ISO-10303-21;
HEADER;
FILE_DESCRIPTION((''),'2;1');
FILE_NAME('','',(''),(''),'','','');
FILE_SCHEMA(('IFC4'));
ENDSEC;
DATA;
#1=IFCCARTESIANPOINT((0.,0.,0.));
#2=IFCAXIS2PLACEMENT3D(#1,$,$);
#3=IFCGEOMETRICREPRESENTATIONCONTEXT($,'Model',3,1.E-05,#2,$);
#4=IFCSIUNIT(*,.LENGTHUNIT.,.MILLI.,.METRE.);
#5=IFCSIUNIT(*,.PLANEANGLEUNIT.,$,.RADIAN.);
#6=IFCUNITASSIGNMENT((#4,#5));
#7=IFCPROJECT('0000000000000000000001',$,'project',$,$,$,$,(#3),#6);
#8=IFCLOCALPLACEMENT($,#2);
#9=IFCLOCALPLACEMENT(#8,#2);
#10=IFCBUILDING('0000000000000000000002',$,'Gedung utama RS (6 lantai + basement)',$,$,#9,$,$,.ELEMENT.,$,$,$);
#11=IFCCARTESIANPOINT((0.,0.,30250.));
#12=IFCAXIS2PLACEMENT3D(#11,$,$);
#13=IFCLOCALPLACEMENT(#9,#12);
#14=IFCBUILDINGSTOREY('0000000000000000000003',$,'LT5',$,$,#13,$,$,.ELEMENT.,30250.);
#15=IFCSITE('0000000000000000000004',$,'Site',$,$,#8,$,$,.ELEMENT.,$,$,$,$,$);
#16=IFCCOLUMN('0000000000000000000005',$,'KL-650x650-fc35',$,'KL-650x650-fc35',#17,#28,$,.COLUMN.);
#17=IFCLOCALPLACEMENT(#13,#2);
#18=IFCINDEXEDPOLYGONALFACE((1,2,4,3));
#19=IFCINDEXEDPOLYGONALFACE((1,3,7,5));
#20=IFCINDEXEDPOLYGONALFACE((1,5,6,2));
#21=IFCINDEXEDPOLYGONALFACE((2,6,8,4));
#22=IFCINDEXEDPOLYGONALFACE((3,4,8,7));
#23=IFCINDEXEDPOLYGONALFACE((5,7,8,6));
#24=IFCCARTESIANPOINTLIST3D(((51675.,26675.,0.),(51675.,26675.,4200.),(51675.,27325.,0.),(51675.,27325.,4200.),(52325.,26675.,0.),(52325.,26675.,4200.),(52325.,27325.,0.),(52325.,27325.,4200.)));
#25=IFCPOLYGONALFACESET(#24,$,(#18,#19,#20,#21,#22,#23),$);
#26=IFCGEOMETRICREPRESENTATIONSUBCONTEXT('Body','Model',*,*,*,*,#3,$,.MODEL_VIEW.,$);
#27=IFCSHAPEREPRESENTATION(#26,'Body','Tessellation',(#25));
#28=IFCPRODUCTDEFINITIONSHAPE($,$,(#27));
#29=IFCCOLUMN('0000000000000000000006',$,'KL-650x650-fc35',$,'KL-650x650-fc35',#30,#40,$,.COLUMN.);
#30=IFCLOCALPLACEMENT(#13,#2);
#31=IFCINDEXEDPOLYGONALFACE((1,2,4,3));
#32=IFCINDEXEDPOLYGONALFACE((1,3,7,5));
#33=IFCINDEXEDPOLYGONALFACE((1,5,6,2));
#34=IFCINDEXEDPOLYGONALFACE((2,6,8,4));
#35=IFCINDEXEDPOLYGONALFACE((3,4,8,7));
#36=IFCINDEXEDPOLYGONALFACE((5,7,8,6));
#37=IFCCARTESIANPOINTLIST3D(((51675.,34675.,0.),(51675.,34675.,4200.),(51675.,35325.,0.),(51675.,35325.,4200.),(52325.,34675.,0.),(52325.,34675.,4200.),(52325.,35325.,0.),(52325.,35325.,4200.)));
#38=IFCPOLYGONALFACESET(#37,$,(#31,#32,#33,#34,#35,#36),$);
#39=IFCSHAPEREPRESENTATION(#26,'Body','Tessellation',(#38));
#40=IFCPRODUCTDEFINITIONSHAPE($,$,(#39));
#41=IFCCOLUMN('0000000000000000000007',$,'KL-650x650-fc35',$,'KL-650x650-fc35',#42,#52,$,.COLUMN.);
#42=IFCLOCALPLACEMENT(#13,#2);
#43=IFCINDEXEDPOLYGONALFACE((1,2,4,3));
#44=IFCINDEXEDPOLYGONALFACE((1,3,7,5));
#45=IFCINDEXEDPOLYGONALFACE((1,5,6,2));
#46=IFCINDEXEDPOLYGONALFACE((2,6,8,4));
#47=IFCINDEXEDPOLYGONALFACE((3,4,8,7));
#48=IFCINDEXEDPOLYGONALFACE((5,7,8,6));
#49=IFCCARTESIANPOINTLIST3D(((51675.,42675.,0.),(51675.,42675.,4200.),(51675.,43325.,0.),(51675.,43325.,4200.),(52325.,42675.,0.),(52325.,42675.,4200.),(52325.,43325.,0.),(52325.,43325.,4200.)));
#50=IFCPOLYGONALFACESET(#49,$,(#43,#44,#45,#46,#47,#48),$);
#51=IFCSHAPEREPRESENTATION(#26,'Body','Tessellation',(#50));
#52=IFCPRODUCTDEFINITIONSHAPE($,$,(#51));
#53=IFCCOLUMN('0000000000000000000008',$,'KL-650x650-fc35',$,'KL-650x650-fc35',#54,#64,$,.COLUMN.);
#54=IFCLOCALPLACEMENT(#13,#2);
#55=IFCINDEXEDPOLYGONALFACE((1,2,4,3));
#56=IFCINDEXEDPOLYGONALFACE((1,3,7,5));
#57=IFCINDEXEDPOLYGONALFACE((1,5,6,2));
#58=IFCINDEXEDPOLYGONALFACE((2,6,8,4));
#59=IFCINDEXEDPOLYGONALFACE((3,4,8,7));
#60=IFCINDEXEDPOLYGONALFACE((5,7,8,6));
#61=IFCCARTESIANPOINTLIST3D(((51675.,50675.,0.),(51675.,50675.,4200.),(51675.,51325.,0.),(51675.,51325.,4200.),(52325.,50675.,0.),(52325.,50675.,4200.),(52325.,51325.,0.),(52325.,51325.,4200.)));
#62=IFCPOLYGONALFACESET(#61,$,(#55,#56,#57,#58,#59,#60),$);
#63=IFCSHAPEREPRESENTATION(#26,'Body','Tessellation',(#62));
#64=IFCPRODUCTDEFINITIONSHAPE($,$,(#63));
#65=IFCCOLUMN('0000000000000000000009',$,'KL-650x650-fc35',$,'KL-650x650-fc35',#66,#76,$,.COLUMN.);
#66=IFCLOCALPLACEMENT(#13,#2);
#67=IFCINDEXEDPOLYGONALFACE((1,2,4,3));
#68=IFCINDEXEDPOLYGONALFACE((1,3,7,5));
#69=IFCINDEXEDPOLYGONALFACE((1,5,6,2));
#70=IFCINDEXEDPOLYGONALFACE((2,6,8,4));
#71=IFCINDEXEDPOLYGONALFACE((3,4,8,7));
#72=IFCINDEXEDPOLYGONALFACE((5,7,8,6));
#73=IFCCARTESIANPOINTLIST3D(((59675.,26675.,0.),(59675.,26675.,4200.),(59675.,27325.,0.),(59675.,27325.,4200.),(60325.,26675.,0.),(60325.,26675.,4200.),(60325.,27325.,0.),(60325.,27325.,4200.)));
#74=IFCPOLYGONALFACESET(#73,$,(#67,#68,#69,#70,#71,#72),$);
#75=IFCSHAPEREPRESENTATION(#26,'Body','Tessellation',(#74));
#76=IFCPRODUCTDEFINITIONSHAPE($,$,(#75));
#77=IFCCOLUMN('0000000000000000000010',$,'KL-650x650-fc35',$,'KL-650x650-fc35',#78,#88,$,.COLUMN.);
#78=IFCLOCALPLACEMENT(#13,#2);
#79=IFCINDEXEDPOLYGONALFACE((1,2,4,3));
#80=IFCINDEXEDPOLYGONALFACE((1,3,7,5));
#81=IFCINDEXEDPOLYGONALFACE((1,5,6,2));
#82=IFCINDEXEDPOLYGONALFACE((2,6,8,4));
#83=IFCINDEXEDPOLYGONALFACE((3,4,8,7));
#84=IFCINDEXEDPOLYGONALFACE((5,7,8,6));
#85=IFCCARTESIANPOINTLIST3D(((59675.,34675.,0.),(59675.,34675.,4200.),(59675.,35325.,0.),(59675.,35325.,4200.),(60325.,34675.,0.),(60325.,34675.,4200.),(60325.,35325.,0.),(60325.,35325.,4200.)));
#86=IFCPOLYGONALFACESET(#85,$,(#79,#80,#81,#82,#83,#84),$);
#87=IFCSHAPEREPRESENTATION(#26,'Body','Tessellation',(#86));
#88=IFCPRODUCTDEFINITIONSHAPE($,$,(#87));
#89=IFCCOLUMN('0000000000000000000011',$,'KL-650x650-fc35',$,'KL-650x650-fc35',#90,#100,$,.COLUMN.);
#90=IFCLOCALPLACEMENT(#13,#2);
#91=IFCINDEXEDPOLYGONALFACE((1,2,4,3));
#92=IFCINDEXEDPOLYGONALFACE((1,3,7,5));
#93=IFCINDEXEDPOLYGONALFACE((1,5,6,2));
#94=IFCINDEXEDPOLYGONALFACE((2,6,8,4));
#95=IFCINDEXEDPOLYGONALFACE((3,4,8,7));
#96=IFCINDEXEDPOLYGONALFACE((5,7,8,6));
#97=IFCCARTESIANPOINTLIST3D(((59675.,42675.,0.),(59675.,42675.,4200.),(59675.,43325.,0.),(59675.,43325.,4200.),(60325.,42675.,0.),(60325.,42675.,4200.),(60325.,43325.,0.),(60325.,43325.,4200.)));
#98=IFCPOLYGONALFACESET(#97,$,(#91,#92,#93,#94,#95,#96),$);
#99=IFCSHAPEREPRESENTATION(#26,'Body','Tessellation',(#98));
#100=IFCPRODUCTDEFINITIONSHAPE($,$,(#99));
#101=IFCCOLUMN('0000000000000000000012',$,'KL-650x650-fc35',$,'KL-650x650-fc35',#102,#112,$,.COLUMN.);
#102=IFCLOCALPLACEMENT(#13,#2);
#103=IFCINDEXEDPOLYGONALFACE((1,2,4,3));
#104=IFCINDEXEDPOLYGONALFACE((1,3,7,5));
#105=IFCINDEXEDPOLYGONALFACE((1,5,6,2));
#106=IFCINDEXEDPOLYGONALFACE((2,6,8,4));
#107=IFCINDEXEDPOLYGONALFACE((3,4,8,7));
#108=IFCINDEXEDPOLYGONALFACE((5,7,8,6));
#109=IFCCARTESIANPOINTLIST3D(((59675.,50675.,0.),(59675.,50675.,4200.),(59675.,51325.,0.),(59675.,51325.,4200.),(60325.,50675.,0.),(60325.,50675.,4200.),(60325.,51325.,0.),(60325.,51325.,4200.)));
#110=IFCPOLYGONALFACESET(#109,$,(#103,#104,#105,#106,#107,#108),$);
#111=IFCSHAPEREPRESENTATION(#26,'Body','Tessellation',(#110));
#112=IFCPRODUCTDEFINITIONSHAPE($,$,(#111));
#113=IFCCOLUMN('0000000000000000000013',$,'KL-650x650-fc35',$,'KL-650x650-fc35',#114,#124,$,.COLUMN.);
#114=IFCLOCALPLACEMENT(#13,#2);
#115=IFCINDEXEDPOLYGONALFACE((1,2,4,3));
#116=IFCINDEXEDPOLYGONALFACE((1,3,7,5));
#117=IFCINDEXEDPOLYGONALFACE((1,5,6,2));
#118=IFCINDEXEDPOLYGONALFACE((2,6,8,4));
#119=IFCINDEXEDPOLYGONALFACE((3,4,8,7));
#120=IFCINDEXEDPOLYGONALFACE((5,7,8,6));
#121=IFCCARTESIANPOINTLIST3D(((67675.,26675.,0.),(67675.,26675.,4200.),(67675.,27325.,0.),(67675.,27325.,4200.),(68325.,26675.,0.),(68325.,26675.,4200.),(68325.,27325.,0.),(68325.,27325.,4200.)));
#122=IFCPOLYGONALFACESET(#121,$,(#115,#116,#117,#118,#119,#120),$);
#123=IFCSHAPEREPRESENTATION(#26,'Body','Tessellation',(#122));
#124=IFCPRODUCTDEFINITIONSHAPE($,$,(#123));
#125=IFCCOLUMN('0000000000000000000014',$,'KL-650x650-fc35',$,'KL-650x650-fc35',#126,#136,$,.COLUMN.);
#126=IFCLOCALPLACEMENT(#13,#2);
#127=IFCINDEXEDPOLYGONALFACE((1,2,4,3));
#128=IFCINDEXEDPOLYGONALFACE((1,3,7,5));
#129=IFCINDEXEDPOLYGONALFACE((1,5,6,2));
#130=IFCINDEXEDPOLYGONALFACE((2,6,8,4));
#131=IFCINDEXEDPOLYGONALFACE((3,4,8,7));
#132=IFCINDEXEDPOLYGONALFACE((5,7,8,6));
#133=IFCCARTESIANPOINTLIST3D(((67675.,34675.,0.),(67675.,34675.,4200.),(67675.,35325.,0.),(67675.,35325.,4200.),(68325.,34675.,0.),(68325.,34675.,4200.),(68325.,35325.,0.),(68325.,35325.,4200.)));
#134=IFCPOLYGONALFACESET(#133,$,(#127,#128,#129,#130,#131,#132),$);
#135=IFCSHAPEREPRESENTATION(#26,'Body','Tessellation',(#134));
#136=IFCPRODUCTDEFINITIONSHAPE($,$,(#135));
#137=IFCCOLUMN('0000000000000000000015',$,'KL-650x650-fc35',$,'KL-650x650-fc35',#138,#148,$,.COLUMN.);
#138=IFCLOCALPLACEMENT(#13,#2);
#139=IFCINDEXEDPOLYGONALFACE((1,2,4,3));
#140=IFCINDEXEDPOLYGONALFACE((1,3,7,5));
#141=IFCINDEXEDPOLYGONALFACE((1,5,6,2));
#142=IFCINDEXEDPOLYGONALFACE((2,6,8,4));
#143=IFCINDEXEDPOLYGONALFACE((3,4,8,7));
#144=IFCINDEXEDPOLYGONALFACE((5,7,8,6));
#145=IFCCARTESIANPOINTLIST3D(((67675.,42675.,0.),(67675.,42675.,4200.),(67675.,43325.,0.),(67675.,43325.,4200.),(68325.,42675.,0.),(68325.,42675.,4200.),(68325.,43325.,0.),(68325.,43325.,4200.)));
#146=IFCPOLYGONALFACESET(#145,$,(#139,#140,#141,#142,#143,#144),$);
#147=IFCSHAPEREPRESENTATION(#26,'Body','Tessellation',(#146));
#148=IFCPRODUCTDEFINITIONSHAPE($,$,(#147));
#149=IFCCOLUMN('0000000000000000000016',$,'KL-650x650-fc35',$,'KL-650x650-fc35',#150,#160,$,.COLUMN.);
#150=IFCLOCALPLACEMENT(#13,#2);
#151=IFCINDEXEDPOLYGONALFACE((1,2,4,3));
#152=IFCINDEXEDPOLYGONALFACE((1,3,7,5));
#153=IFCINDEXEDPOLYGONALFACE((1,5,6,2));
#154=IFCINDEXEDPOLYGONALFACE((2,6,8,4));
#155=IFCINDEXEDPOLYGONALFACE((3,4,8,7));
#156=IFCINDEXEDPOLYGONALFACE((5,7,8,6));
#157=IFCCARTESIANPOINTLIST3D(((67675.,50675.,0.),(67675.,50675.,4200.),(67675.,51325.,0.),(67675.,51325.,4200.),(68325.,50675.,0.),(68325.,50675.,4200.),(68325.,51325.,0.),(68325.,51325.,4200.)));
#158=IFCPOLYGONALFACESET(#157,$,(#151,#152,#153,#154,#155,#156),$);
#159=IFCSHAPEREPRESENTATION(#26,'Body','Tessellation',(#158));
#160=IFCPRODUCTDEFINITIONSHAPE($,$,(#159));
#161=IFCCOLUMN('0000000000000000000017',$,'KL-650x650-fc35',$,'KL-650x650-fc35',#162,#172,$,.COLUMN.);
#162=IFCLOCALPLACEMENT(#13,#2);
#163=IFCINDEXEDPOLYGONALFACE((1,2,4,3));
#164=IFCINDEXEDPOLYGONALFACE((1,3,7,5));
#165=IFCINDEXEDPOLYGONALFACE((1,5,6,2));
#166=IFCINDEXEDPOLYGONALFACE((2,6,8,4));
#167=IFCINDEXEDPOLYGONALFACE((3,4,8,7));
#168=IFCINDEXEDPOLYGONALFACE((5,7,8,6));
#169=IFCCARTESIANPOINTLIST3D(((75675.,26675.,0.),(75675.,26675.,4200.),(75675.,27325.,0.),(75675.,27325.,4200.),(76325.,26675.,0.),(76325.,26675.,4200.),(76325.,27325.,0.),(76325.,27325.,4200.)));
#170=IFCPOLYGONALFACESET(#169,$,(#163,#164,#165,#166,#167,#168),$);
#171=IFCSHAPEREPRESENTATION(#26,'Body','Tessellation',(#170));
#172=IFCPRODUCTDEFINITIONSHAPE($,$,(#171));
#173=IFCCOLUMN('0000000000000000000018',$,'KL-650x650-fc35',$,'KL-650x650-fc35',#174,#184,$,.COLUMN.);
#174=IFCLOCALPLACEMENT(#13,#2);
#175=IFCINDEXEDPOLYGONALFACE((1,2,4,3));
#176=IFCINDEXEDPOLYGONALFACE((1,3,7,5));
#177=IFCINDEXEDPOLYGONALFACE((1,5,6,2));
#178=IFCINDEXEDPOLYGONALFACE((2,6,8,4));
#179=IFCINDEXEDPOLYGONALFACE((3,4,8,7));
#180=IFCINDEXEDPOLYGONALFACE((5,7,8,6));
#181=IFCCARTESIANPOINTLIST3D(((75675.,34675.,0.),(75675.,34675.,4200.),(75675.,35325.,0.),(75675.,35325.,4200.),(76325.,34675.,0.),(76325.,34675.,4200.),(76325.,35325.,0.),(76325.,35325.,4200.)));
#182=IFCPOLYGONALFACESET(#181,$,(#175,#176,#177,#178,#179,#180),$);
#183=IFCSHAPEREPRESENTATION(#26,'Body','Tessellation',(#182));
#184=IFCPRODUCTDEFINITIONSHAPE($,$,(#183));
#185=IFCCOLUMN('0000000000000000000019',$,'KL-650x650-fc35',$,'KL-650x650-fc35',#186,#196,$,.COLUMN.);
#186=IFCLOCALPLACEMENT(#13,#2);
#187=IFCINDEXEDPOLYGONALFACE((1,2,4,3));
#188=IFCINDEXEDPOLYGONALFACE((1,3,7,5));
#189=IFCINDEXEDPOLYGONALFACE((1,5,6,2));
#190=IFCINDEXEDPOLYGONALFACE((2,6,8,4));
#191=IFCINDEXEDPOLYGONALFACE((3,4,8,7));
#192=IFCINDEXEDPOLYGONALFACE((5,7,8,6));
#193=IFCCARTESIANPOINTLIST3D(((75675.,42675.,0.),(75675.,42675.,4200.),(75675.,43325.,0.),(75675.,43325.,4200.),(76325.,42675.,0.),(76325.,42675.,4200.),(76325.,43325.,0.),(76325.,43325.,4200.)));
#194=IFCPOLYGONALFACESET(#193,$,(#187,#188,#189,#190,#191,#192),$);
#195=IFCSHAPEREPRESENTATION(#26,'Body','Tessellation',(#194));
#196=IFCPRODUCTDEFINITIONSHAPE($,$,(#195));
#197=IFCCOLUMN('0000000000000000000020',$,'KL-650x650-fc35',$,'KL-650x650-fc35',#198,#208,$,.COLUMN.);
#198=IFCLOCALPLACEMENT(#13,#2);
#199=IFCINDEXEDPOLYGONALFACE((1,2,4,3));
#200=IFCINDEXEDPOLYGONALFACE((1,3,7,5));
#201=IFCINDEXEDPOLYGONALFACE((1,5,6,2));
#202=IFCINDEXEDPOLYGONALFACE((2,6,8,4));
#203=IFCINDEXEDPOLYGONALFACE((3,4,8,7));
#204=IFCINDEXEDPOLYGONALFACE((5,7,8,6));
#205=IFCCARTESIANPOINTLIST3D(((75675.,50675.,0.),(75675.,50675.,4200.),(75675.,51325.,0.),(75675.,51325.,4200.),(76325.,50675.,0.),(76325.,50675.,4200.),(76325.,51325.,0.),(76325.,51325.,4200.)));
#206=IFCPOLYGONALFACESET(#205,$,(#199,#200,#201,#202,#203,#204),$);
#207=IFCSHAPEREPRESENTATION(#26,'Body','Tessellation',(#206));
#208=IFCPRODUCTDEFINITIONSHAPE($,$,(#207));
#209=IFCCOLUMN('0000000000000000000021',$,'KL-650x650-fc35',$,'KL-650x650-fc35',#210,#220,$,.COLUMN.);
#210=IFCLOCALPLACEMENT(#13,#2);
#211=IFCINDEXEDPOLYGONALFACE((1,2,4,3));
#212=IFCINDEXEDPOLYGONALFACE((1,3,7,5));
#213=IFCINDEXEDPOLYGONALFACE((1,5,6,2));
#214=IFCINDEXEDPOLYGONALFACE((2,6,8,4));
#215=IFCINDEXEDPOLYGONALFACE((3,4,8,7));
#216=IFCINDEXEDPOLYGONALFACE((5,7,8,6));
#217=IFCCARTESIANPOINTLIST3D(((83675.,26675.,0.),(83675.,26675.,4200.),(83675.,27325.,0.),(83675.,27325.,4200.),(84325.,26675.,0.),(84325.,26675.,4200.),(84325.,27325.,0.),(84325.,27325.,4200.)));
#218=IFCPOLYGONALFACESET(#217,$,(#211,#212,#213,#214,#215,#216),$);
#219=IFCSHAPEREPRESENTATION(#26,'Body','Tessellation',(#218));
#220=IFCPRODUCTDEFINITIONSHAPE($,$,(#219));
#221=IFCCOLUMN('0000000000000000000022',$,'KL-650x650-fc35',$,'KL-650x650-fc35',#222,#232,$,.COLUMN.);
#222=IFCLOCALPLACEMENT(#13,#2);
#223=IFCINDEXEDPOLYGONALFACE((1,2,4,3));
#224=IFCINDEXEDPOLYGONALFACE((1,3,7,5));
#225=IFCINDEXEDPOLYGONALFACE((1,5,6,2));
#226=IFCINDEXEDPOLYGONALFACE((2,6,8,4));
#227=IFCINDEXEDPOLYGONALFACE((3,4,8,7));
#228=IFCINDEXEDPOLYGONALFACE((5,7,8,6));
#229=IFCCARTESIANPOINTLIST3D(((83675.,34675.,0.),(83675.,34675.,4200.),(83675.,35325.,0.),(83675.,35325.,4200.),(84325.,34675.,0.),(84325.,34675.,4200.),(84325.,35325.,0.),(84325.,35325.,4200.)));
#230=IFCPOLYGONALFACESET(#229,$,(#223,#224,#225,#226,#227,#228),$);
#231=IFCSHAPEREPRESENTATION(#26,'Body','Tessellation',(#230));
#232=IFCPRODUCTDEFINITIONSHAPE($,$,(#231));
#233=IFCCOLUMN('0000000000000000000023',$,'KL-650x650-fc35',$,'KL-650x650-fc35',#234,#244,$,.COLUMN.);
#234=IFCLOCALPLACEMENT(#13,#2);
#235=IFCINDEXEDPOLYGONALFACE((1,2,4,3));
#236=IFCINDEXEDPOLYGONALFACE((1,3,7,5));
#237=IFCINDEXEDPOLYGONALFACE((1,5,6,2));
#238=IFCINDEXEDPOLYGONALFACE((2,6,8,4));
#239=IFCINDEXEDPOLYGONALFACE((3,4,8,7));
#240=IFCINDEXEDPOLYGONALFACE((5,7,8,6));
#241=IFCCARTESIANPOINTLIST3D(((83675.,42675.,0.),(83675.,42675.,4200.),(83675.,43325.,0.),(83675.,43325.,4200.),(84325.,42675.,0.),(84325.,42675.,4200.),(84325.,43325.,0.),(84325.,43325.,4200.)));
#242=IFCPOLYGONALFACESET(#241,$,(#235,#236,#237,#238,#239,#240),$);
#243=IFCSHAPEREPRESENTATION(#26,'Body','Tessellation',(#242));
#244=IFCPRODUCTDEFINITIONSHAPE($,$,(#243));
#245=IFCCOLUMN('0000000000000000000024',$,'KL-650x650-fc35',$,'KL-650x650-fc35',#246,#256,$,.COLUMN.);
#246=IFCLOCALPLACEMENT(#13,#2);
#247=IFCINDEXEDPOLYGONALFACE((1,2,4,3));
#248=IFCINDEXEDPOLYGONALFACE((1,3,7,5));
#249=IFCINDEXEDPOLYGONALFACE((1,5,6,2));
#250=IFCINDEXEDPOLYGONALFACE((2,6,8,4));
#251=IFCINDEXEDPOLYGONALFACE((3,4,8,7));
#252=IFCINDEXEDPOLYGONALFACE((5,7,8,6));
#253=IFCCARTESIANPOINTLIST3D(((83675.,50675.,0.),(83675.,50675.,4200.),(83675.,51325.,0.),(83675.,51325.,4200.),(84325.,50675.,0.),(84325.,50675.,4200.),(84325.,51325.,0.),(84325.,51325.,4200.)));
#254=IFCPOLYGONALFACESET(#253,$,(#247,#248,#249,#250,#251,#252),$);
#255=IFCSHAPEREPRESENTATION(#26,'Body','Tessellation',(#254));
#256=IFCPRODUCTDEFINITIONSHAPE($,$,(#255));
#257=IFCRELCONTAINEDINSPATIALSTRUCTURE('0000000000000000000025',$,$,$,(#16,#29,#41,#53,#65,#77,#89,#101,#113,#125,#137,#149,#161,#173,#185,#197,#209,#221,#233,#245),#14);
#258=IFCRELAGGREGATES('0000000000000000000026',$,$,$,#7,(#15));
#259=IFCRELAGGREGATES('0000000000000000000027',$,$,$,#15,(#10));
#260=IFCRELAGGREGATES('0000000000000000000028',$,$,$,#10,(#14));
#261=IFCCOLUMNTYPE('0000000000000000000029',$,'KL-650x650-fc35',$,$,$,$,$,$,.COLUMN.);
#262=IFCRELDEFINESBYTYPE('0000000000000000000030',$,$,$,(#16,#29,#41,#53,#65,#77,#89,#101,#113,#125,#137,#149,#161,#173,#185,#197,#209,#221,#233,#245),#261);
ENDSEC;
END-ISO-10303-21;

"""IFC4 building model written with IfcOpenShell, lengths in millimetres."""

from ifc_helpers import new_model, si_unit, frame, origin, origin_2d, place, context, subcontext, project, spatial, rectangle, extrude, material_profile, profile_set, profile_usage, type_object, element, save


model = new_model("IFC4")

# Units and contexts
model_context = context("Model", 3, precision=1e-05, world=origin())
body_context = subcontext(model_context, "Body", "Model", "MODEL_VIEW")
ifc_project = project(units=[si_unit("LENGTHUNIT", "METRE", prefix="MILLI"), si_unit("PLANEANGLEUNIT", "RADIAN")], contexts=[model_context])

# Site, building, storey
site_placement = place(None, origin())
site = spatial("IfcSite", under=ifc_project, at=site_placement, Name="Site", CompositionType="ELEMENT")
building_placement = place(site_placement, origin())
building = spatial("IfcBuilding", under=site, at=building_placement, Name="Gedung utama RS (6 lantai + basement)", CompositionType="ELEMENT")
storey_placement = place(building_placement, frame((0.0, 0.0, 30250.0)))
storey = spatial("IfcBuildingStorey", under=building, at=storey_placement, Name="LT5", CompositionType="ELEMENT", Elevation=30250.0)

# Columns
ifc_material_profile_1 = material_profile(None, rectangle(XDim=650.0, YDim=650.0, at=origin_2d()), Name="KL-650x650-fc35")
ifc_profile_set_1 = profile_set([ifc_material_profile_1], Name="KL-650x650-fc35")
ifc_profile_usage_1 = profile_usage(ifc_profile_set_1, cardinal=5)
column_type = type_object("IfcColumnType", Name="KL-650x650-fc35", PredefinedType="COLUMN", material=ifc_profile_set_1)
for number, where, z_axis, x_axis, name in (
    (1, (52000.0, 27000.0, 0.0), (0.0, 0.0, 1.0), (1.0, 0.0, 0.0), "KL-650x650-fc35"),
    (2, (52000.0, 35000.0, 0.0), (0.0, 0.0, 1.0), (1.0, 0.0, 0.0), "KL-650x650-fc35"),
    (3, (52000.0, 43000.0, 0.0), (0.0, 0.0, 1.0), (1.0, 0.0, 0.0), "KL-650x650-fc35"),
    (4, (52000.0, 51000.0, 0.0), (0.0, 0.0, 1.0), (1.0, 0.0, 0.0), "KL-650x650-fc35"),
    (5, (60000.0, 27000.0, 0.0), (0.0, 0.0, 1.0), (1.0, 0.0, 0.0), "KL-650x650-fc35"),
    (6, (60000.0, 35000.0, 0.0), (0.0, 0.0, 1.0), (1.0, 0.0, 0.0), "KL-650x650-fc35"),
    (7, (60000.0, 43000.0, 0.0), (0.0, 0.0, 1.0), (1.0, 0.0, 0.0), "KL-650x650-fc35"),
    (8, (60000.0, 51000.0, 0.0), (0.0, 0.0, 1.0), (1.0, 0.0, 0.0), "KL-650x650-fc35"),
    (9, (68000.0, 27000.0, 0.0), (0.0, 0.0, 1.0), (1.0, 0.0, 0.0), "KL-650x650-fc35"),
    (10, (68000.0, 35000.0, 0.0), (0.0, 0.0, 1.0), (1.0, 0.0, 0.0), "KL-650x650-fc35"),
    (11, (68000.0, 43000.0, 0.0), (0.0, 0.0, 1.0), (1.0, 0.0, 0.0), "KL-650x650-fc35"),
    (12, (68000.0, 51000.0, 0.0), (0.0, 0.0, 1.0), (1.0, 0.0, 0.0), "KL-650x650-fc35"),
    (13, (76000.0, 27000.0, 0.0), (0.0, 0.0, 1.0), (1.0, 0.0, 0.0), "KL-650x650-fc35"),
    (14, (76000.0, 35000.0, 0.0), (0.0, 0.0, 1.0), (1.0, 0.0, 0.0), "KL-650x650-fc35"),
    (15, (76000.0, 43000.0, 0.0), (0.0, 0.0, 1.0), (1.0, 0.0, 0.0), "KL-650x650-fc35"),
    (16, (76000.0, 51000.0, 0.0), (0.0, 0.0, 1.0), (1.0, 0.0, 0.0), "KL-650x650-fc35"),
    (17, (84000.0, 27000.0, 0.0), (0.0, 0.0, 1.0), (1.0, 0.0, 0.0), "KL-650x650-fc35"),
    (18, (84000.0, 35000.0, 0.0), (0.0, 0.0, 1.0), (1.0, 0.0, 0.0), "KL-650x650-fc35"),
    (19, (84000.0, 43000.0, 0.0), (0.0, 0.0, 1.0), (1.0, 0.0, 0.0), "KL-650x650-fc35"),
    (20, (84000.0, 51000.0, 0.0), (0.0, 0.0, 1.0), (1.0, 0.0, 0.0), "KL-650x650-fc35"),
):
    element("IfcColumn", number, at=place(storey_placement, frame(where, z_axis=z_axis, x_axis=x_axis)), inside=storey, type_object=column_type, material=ifc_profile_usage_1, Name=name, ObjectType="KL-650x650-fc35", PredefinedType="COLUMN", context=body_context, shape_type="SweptSolid", body=[
        extrude(rectangle(XDim=650.0, YDim=650.0, at=origin_2d()), origin(), (0.0, 0.0, 1.0), 4200.0),
    ])

save(model, "model.ifc")
